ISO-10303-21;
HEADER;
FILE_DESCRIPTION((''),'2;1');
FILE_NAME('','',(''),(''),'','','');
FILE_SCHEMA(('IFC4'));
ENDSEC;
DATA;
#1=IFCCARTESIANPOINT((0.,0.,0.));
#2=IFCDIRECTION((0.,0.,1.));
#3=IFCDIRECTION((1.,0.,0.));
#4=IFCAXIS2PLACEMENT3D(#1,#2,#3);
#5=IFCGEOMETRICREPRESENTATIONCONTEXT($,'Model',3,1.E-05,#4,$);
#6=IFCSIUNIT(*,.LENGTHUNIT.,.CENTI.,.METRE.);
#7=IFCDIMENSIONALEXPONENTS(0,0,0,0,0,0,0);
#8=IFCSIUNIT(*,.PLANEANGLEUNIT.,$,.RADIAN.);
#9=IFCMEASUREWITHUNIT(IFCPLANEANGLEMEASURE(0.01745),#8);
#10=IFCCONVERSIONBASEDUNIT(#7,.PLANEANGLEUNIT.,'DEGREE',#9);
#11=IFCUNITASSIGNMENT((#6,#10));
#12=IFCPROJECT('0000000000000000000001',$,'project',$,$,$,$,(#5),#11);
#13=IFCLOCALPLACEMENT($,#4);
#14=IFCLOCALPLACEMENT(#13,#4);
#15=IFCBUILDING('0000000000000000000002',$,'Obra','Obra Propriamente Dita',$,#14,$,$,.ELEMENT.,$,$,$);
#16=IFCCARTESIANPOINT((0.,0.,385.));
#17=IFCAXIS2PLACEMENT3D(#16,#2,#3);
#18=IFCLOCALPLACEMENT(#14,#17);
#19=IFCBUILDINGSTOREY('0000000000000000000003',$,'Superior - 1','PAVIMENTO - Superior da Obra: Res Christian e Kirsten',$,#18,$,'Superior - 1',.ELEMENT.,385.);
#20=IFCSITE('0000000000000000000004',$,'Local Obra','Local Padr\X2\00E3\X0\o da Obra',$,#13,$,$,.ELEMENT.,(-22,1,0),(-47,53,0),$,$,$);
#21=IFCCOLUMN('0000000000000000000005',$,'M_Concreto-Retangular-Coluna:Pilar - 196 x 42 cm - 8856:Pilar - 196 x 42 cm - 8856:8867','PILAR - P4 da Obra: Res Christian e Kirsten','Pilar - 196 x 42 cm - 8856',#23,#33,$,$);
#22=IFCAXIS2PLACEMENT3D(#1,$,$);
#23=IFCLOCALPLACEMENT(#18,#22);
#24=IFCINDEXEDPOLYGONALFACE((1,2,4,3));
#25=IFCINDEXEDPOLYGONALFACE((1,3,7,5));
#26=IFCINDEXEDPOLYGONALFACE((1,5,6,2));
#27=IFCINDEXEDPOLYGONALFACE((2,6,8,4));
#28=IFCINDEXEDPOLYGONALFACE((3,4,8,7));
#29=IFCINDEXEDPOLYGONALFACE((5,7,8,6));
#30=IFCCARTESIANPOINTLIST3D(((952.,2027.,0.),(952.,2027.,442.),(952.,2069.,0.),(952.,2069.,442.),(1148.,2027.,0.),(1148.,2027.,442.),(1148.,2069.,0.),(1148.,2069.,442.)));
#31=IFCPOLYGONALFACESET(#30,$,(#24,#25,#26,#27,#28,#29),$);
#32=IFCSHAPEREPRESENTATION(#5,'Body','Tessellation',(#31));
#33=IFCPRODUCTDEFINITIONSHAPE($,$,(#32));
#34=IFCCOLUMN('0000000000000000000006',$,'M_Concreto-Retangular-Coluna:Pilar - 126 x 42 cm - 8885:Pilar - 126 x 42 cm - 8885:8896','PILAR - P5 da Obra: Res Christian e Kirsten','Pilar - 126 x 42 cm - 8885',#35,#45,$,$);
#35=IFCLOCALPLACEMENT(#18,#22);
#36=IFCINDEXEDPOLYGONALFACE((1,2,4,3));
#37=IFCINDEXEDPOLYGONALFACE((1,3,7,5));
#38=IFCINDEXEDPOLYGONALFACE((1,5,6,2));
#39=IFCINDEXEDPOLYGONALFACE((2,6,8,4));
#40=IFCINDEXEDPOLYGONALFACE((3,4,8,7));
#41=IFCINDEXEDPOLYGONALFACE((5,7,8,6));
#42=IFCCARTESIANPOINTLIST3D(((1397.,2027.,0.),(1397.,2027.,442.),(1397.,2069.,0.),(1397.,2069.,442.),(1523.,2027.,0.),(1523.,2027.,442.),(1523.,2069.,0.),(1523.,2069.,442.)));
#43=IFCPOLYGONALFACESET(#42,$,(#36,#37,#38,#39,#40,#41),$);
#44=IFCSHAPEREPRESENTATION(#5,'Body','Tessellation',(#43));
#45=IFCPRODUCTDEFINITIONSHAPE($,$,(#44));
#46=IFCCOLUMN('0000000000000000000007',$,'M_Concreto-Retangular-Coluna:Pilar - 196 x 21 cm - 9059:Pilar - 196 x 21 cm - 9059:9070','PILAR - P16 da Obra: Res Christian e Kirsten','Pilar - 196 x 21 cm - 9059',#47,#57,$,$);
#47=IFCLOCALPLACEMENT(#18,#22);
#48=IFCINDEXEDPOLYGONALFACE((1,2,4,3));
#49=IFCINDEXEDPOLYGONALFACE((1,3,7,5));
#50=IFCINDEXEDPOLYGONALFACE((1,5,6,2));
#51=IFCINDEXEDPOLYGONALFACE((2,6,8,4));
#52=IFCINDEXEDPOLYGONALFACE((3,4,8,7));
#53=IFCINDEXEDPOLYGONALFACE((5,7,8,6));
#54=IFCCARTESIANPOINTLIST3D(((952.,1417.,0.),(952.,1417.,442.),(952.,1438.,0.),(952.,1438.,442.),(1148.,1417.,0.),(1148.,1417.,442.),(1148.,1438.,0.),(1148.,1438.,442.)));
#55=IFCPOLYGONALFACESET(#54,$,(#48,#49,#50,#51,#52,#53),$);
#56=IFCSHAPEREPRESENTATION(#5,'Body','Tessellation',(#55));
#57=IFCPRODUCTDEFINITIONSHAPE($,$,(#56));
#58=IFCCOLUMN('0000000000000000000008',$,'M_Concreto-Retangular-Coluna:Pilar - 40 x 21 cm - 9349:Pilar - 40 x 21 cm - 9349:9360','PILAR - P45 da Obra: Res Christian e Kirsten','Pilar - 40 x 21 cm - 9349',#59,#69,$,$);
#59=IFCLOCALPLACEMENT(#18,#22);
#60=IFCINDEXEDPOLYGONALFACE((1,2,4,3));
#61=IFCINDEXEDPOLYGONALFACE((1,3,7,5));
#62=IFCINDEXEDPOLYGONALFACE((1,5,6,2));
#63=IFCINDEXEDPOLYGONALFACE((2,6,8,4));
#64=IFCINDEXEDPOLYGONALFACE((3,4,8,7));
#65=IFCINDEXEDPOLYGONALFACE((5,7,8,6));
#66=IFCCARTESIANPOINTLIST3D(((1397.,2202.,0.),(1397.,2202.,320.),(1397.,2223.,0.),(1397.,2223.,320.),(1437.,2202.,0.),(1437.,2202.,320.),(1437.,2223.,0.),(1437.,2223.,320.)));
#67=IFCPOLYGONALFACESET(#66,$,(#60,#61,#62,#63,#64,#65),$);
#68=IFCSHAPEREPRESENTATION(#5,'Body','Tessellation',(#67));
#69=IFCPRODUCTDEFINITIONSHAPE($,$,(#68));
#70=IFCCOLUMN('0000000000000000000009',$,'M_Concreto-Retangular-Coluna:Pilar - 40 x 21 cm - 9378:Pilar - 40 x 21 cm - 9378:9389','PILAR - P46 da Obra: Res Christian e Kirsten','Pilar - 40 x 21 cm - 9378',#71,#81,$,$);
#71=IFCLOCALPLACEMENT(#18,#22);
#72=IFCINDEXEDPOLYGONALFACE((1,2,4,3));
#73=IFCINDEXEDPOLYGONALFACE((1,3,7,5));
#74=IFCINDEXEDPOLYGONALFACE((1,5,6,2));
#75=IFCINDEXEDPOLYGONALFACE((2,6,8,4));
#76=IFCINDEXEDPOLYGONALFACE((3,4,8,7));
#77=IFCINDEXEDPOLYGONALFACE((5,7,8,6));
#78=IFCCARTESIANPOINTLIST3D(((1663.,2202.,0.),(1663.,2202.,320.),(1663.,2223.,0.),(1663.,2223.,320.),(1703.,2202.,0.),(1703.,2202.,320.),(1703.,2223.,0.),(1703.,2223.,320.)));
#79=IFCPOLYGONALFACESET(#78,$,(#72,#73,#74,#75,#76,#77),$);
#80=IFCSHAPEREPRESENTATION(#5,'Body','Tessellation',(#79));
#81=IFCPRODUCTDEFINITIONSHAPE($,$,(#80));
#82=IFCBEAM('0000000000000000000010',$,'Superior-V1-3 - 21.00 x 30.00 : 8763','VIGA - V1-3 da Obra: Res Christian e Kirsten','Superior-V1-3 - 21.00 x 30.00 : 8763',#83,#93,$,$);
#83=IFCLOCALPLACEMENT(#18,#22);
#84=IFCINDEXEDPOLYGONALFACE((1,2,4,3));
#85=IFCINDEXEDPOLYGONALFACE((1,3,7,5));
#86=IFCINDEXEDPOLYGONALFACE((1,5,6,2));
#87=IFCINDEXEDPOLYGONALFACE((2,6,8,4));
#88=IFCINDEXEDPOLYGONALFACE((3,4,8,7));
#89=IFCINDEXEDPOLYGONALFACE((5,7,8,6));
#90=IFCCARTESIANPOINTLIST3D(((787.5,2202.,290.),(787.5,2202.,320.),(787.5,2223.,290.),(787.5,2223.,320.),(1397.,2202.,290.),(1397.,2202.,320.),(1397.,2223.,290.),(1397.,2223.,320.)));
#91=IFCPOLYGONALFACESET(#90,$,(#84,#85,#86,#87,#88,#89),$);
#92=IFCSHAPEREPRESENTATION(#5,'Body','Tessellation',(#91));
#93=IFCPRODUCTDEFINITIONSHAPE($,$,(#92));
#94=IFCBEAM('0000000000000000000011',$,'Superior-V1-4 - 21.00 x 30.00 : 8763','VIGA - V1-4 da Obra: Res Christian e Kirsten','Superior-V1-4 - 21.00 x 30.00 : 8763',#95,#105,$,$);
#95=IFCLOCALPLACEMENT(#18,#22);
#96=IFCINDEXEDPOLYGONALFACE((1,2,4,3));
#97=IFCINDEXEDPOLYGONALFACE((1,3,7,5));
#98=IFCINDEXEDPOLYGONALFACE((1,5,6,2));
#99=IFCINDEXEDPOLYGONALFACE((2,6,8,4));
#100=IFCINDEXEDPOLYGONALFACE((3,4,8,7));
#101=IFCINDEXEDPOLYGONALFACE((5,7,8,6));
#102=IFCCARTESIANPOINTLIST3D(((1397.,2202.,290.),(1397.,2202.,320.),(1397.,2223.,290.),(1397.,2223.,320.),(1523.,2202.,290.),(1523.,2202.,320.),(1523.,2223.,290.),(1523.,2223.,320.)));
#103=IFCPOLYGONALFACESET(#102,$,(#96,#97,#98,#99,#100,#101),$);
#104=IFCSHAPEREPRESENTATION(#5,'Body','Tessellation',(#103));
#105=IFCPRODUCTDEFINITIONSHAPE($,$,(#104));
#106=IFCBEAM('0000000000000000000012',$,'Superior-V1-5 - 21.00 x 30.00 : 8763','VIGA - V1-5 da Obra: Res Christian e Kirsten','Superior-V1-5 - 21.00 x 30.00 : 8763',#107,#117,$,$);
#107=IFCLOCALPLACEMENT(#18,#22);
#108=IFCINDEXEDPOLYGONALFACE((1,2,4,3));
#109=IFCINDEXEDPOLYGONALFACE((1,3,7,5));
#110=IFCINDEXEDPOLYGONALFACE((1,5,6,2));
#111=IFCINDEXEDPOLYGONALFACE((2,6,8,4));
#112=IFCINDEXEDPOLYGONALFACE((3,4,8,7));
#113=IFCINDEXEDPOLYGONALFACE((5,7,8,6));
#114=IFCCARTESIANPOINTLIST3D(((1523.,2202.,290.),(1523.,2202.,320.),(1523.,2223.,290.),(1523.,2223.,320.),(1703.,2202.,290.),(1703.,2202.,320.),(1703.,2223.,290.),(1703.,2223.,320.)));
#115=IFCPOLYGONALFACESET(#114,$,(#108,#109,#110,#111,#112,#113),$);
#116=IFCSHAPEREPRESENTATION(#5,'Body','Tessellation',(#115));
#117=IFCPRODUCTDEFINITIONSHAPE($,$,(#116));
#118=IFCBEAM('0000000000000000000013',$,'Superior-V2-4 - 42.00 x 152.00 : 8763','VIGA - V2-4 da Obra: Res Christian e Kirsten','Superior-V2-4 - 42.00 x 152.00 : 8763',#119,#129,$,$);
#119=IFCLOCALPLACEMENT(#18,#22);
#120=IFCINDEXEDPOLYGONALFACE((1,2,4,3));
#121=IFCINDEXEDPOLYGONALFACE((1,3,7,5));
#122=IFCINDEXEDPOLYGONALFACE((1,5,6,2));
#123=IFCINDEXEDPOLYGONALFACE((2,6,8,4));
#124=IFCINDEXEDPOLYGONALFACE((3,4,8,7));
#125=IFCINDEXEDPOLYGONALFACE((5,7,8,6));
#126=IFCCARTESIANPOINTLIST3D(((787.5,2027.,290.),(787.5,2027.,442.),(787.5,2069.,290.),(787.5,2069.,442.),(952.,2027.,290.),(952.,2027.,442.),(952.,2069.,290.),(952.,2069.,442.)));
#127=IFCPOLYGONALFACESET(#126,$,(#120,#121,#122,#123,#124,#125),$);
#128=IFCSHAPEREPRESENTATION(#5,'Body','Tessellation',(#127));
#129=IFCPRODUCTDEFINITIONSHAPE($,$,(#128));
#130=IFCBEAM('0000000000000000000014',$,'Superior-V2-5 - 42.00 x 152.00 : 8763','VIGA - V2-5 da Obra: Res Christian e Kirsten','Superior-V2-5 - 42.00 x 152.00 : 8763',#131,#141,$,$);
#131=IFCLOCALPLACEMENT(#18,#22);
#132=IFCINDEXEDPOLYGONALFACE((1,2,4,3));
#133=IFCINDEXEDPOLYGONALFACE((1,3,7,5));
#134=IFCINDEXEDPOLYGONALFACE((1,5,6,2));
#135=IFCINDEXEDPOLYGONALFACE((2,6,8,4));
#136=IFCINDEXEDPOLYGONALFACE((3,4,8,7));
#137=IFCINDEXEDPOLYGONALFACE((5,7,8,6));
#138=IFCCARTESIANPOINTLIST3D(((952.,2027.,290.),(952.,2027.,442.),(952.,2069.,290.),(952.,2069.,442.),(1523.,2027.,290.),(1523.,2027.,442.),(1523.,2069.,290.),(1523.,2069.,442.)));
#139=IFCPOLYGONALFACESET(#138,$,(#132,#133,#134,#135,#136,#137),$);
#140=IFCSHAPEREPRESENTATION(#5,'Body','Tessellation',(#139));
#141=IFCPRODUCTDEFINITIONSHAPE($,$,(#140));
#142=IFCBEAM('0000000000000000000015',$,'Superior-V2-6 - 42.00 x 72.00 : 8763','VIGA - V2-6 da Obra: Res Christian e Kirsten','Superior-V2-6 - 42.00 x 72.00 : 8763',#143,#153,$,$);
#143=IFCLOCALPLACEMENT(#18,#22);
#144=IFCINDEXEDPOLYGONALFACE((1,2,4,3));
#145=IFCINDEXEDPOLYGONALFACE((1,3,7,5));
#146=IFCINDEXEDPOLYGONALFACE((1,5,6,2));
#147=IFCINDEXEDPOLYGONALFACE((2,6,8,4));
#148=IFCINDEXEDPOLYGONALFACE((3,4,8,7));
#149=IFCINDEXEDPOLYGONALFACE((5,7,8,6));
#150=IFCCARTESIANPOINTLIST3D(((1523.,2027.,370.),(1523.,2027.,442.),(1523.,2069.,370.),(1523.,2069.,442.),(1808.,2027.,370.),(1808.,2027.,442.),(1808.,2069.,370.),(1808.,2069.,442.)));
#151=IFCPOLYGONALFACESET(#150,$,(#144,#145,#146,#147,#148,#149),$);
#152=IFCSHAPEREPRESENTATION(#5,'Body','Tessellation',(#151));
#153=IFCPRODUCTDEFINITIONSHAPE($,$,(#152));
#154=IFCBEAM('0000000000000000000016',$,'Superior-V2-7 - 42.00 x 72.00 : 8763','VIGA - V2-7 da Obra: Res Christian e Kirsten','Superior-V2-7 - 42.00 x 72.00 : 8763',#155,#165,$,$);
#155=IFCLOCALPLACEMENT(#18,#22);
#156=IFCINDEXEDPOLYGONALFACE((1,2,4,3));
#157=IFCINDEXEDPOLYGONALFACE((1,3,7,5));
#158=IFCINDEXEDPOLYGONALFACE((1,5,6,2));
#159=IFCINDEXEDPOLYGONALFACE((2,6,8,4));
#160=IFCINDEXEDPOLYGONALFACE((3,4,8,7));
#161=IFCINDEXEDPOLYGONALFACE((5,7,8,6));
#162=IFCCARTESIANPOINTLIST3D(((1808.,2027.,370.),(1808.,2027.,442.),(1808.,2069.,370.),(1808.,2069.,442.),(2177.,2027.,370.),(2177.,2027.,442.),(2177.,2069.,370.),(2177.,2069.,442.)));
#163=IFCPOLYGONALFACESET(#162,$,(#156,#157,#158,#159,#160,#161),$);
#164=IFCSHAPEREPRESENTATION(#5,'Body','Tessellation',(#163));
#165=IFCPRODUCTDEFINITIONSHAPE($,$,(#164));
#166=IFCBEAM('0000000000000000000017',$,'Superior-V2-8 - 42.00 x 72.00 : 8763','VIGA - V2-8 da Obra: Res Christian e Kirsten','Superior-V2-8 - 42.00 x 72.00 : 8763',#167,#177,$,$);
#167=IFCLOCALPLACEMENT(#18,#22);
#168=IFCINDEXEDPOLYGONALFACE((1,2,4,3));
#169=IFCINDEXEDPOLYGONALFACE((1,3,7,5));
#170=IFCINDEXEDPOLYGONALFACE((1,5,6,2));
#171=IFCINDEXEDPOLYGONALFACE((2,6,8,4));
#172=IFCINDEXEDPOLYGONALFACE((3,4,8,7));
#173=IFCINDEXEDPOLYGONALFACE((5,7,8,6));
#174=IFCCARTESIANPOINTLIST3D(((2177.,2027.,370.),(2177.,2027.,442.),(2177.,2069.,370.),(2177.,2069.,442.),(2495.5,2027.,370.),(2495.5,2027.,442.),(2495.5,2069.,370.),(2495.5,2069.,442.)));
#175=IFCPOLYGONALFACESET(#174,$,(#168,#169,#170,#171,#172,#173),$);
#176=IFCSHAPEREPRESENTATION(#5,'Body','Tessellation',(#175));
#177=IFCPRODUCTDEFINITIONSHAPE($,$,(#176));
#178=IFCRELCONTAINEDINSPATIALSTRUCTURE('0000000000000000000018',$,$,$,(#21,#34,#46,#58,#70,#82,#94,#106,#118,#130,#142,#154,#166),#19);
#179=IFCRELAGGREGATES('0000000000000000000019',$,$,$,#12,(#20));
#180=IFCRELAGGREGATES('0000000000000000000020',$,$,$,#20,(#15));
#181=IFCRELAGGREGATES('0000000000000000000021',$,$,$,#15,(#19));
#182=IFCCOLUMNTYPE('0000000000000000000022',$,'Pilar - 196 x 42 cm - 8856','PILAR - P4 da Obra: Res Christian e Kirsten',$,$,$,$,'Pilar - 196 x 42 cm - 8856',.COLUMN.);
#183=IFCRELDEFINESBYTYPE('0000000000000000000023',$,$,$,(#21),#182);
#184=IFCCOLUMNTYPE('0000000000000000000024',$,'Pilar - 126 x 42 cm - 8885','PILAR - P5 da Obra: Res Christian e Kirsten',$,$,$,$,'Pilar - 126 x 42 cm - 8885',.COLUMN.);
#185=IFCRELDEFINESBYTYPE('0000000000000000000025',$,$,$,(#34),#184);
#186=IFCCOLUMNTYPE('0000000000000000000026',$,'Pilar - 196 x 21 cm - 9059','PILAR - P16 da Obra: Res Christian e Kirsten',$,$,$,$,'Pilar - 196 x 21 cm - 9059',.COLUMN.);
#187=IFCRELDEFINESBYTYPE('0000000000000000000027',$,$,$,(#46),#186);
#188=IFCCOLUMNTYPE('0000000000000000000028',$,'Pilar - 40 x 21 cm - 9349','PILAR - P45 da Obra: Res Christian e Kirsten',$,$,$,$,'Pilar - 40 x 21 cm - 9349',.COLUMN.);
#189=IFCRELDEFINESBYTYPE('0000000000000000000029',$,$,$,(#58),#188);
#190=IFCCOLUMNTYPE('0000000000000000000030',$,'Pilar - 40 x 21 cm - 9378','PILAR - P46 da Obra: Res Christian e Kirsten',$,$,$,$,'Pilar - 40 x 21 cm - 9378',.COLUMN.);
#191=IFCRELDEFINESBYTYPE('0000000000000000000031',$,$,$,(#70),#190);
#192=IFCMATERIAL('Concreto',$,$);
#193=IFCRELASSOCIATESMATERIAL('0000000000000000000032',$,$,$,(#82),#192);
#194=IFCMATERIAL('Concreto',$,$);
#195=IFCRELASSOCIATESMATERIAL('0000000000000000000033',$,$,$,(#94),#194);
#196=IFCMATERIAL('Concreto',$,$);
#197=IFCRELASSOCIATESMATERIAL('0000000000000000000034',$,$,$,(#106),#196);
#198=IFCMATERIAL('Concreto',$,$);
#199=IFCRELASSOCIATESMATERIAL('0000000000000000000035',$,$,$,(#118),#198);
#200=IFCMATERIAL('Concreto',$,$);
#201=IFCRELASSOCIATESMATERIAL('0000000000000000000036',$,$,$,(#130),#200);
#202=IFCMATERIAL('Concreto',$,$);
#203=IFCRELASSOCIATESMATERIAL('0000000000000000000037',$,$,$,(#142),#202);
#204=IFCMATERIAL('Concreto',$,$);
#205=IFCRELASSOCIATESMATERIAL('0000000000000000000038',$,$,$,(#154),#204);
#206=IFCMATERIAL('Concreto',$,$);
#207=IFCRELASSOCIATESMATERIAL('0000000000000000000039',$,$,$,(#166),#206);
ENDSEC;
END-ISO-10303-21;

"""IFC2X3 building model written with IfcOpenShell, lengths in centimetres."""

from ifc_helpers import new_model, entity, si_unit, converted_unit, frame, origin, origin_with_axes, origin_2d_with_axis, place, context, project, spatial, polyline, rectangle, outline, extrude, source, transform, mapped, material, type_object, type_shapes, element, save


model = new_model("IFC2X3")

# Units and contexts
model_context = context("Model", 3, precision=1e-05, world=origin_with_axes())
ifc_project = project(units=[si_unit("LENGTHUNIT", "METRE", prefix="CENTI"), converted_unit("PLANEANGLEUNIT", "DEGREE", entity("IfcPlaneAngleMeasure", 0.01745), si_unit("PLANEANGLEUNIT", "RADIAN"), dimensions=[0, 0, 0, 0, 0, 0, 0])], contexts=[model_context])

# Site, building, storey
site_placement = place(None, origin_with_axes())
site = spatial("IfcSite", under=ifc_project, at=site_placement, Name="Local Obra", Description="Local Padrão da Obra", CompositionType="ELEMENT", RefLatitude=(-22, 1, 0), RefLongitude=(-47, 53, 0))
building_placement = place(site_placement, origin_with_axes())
building = spatial("IfcBuilding", under=site, at=building_placement, Name="Obra", Description="Obra Propriamente Dita", CompositionType="ELEMENT")
storey_placement = place(building_placement, frame((0.0, 0.0, 385.0), z_axis=(0.0, 0.0, 1.0), x_axis=(1.0, 0.0, 0.0)))
storey = spatial("IfcBuildingStorey", under=building, at=storey_placement, Name="Superior - 1", Description="PAVIMENTO - Superior da Obra: Res Christian e Kirsten", LongName="Superior - 1", CompositionType="ELEMENT", Elevation=385.0)

# Columns
column_type_1 = type_object("IfcColumnType", Name="Pilar - 196 x 42 cm - 8856", Description="PILAR - P4 da Obra: Res Christian e Kirsten", ElementType="Pilar - 196 x 42 cm - 8856", PredefinedType="COLUMN")
shared_shape_1 = source(origin(), model_context, "Body", "SweptSolid", [
    extrude(rectangle(XDim=196.0, YDim=42.0, at=origin_2d_with_axis()), origin(), (0.0, 0.0, 1.0), 442.0),
])
type_shapes(column_type_1, [shared_shape_1])
column_1_placement = place(storey_placement, frame((1050.0, 2048.0, 0.0), z_axis=(0.0, 0.0, 1.0), x_axis=(1.0, 0.0, 0.0)))
element("IfcColumn", 1, at=column_1_placement, inside=storey, type_object=column_type_1, Name="M_Concreto-Retangular-Coluna:Pilar - 196 x 42 cm - 8856:Pilar - 196 x 42 cm - 8856:8867", Description="PILAR - P4 da Obra: Res Christian e Kirsten", ObjectType="Pilar - 196 x 42 cm - 8856", context=model_context, shape_type="MappedRepresentation", body=[
    mapped(shared_shape_1, transform((0.0, 0.0, 0.0), scale=1.0)),
])
column_type_2 = type_object("IfcColumnType", Name="Pilar - 126 x 42 cm - 8885", Description="PILAR - P5 da Obra: Res Christian e Kirsten", ElementType="Pilar - 126 x 42 cm - 8885", PredefinedType="COLUMN")
shared_shape_2 = source(origin(), model_context, "Body", "SweptSolid", [
    extrude(rectangle(XDim=126.0, YDim=42.0, at=origin_2d_with_axis()), origin(), (0.0, 0.0, 1.0), 442.0),
])
type_shapes(column_type_2, [shared_shape_2])
column_2_placement = place(storey_placement, frame((1460.0, 2048.0, 0.0), z_axis=(0.0, 0.0, 1.0), x_axis=(1.0, 0.0, 0.0)))
element("IfcColumn", 2, at=column_2_placement, inside=storey, type_object=column_type_2, Name="M_Concreto-Retangular-Coluna:Pilar - 126 x 42 cm - 8885:Pilar - 126 x 42 cm - 8885:8896", Description="PILAR - P5 da Obra: Res Christian e Kirsten", ObjectType="Pilar - 126 x 42 cm - 8885", context=model_context, shape_type="MappedRepresentation", body=[
    mapped(shared_shape_2, transform((0.0, 0.0, 0.0), scale=1.0)),
])
column_type_3 = type_object("IfcColumnType", Name="Pilar - 196 x 21 cm - 9059", Description="PILAR - P16 da Obra: Res Christian e Kirsten", ElementType="Pilar - 196 x 21 cm - 9059", PredefinedType="COLUMN")
shared_shape_3 = source(origin(), model_context, "Body", "SweptSolid", [
    extrude(rectangle(XDim=196.0, YDim=21.0, at=origin_2d_with_axis()), origin(), (0.0, 0.0, 1.0), 442.0),
])
type_shapes(column_type_3, [shared_shape_3])
column_3_placement = place(storey_placement, frame((1050.0, 1427.5, 0.0), z_axis=(0.0, 0.0, 1.0), x_axis=(1.0, 0.0, 0.0)))
element("IfcColumn", 3, at=column_3_placement, inside=storey, type_object=column_type_3, Name="M_Concreto-Retangular-Coluna:Pilar - 196 x 21 cm - 9059:Pilar - 196 x 21 cm - 9059:9070", Description="PILAR - P16 da Obra: Res Christian e Kirsten", ObjectType="Pilar - 196 x 21 cm - 9059", context=model_context, shape_type="MappedRepresentation", body=[
    mapped(shared_shape_3, transform((0.0, 0.0, 0.0), scale=1.0)),
])
column_type_4 = type_object("IfcColumnType", Name="Pilar - 40 x 21 cm - 9349", Description="PILAR - P45 da Obra: Res Christian e Kirsten", ElementType="Pilar - 40 x 21 cm - 9349", PredefinedType="COLUMN")
shared_shape_4 = source(origin(), model_context, "Body", "SweptSolid", [
    extrude(rectangle(XDim=40.0, YDim=21.0, at=origin_2d_with_axis()), origin(), (0.0, 0.0, 1.0), 320.0),
])
type_shapes(column_type_4, [shared_shape_4])
column_4_placement = place(storey_placement, frame((1417.0, 2212.5, 0.0), z_axis=(0.0, 0.0, 1.0), x_axis=(1.0, 0.0, 0.0)))
element("IfcColumn", 4, at=column_4_placement, inside=storey, type_object=column_type_4, Name="M_Concreto-Retangular-Coluna:Pilar - 40 x 21 cm - 9349:Pilar - 40 x 21 cm - 9349:9360", Description="PILAR - P45 da Obra: Res Christian e Kirsten", ObjectType="Pilar - 40 x 21 cm - 9349", context=model_context, shape_type="MappedRepresentation", body=[
    mapped(shared_shape_4, transform((0.0, 0.0, 0.0), scale=1.0)),
])
column_type_5 = type_object("IfcColumnType", Name="Pilar - 40 x 21 cm - 9378", Description="PILAR - P46 da Obra: Res Christian e Kirsten", ElementType="Pilar - 40 x 21 cm - 9378", PredefinedType="COLUMN")
shared_shape_5 = source(origin(), model_context, "Body", "SweptSolid", [
    extrude(rectangle(XDim=40.0, YDim=21.0, at=origin_2d_with_axis()), origin(), (0.0, 0.0, 1.0), 320.0),
])
type_shapes(column_type_5, [shared_shape_5])
column_5_placement = place(storey_placement, frame((1683.0, 2212.5, 0.0), z_axis=(0.0, 0.0, 1.0), x_axis=(1.0, 0.0, 0.0)))
element("IfcColumn", 5, at=column_5_placement, inside=storey, type_object=column_type_5, Name="M_Concreto-Retangular-Coluna:Pilar - 40 x 21 cm - 9378:Pilar - 40 x 21 cm - 9378:9389", Description="PILAR - P46 da Obra: Res Christian e Kirsten", ObjectType="Pilar - 40 x 21 cm - 9378", context=model_context, shape_type="MappedRepresentation", body=[
    mapped(shared_shape_5, transform((0.0, 0.0, 0.0), scale=1.0)),
])

# Beams
ifc_material_1 = material(Name="Concreto")
beam_1_placement = place(storey_placement, frame((787.5, 2223.0, 320.0), z_axis=(1.0, 0.0, 0.0), x_axis=(0.0, -1.0, 0.0)))
element("IfcBeam", 6, at=beam_1_placement, inside=storey, material=ifc_material_1, Name="Superior-V1-3 - 21.00 x 30.00 : 8763", Description="VIGA - V1-3 da Obra: Res Christian e Kirsten", ObjectType="Superior-V1-3 - 21.00 x 30.00 : 8763", context=model_context, shape_type="SweptSolid", body=[
    extrude(outline(polyline([(0.0, 0.0), (21.0, 0.0), (21.0, 30.0), (0.0, 30.0), (0.0, 0.0)])), origin_with_axes(), (0.0, 0.0, 1.0), 609.5),
])
ifc_material_2 = material(Name="Concreto")
beam_2_placement = place(storey_placement, frame((1397.0, 2223.0, 320.0), z_axis=(1.0, 0.0, 0.0), x_axis=(0.0, -1.0, 0.0)))
element("IfcBeam", 7, at=beam_2_placement, inside=storey, material=ifc_material_2, Name="Superior-V1-4 - 21.00 x 30.00 : 8763", Description="VIGA - V1-4 da Obra: Res Christian e Kirsten", ObjectType="Superior-V1-4 - 21.00 x 30.00 : 8763", context=model_context, shape_type="SweptSolid", body=[
    extrude(outline(polyline([(0.0, 0.0), (21.0, 0.0), (21.0, 30.0), (0.0, 30.0), (0.0, 0.0)])), origin_with_axes(), (0.0, 0.0, 1.0), 126.0),
])
ifc_material_3 = material(Name="Concreto")
beam_3_placement = place(storey_placement, frame((1523.0, 2223.0, 320.0), z_axis=(1.0, 0.0, 0.0), x_axis=(0.0, -1.0, 0.0)))
element("IfcBeam", 8, at=beam_3_placement, inside=storey, material=ifc_material_3, Name="Superior-V1-5 - 21.00 x 30.00 : 8763", Description="VIGA - V1-5 da Obra: Res Christian e Kirsten", ObjectType="Superior-V1-5 - 21.00 x 30.00 : 8763", context=model_context, shape_type="SweptSolid", body=[
    extrude(outline(polyline([(0.0, 0.0), (21.0, 0.0), (21.0, 30.0), (0.0, 30.0), (0.0, 0.0)])), origin_with_axes(), (0.0, 0.0, 1.0), 180.0),
])
ifc_material_4 = material(Name="Concreto")
beam_4_placement = place(storey_placement, frame((787.5, 2048.0, 442.0), z_axis=(1.0, 0.0, 0.0), x_axis=(0.0, -1.0, 0.0)))
element("IfcBeam", 9, at=beam_4_placement, inside=storey, material=ifc_material_4, Name="Superior-V2-4 - 42.00 x 152.00 : 8763", Description="VIGA - V2-4 da Obra: Res Christian e Kirsten", ObjectType="Superior-V2-4 - 42.00 x 152.00 : 8763", context=model_context, shape_type="SweptSolid", body=[
    extrude(outline(polyline([(-21.0, 0.0), (21.0, 0.0), (21.0, 152.0), (-21.0, 152.0), (-21.0, 0.0)])), origin_with_axes(), (0.0, 0.0, 1.0), 164.5),
])
ifc_material_5 = material(Name="Concreto")
beam_5_placement = place(storey_placement, frame((952.0, 2048.0, 442.0), z_axis=(1.0, 0.0, 0.0), x_axis=(0.0, -1.0, 0.0)))
element("IfcBeam", 10, at=beam_5_placement, inside=storey, material=ifc_material_5, Name="Superior-V2-5 - 42.00 x 152.00 : 8763", Description="VIGA - V2-5 da Obra: Res Christian e Kirsten", ObjectType="Superior-V2-5 - 42.00 x 152.00 : 8763", context=model_context, shape_type="SweptSolid", body=[
    extrude(outline(polyline([(-21.0, 0.0), (21.0, 0.0), (21.0, 152.0), (-21.0, 152.0), (-21.0, 0.0)])), origin_with_axes(), (0.0, 0.0, 1.0), 571.0),
])
ifc_material_6 = material(Name="Concreto")
beam_6_placement = place(storey_placement, frame((1523.0, 2048.0, 442.0), z_axis=(1.0, 0.0, 0.0), x_axis=(0.0, -1.0, 0.0)))
element("IfcBeam", 11, at=beam_6_placement, inside=storey, material=ifc_material_6, Name="Superior-V2-6 - 42.00 x 72.00 : 8763", Description="VIGA - V2-6 da Obra: Res Christian e Kirsten", ObjectType="Superior-V2-6 - 42.00 x 72.00 : 8763", context=model_context, shape_type="SweptSolid", body=[
    extrude(outline(polyline([(-21.0, 0.0), (21.0, 0.0), (21.0, 72.0), (-21.0, 72.0), (-21.0, 0.0)])), origin_with_axes(), (0.0, 0.0, 1.0), 285.0),
])
ifc_material_7 = material(Name="Concreto")
beam_7_placement = place(storey_placement, frame((1808.0, 2048.0, 442.0), z_axis=(1.0, 0.0, 0.0), x_axis=(0.0, -1.0, 0.0)))
element("IfcBeam", 12, at=beam_7_placement, inside=storey, material=ifc_material_7, Name="Superior-V2-7 - 42.00 x 72.00 : 8763", Description="VIGA - V2-7 da Obra: Res Christian e Kirsten", ObjectType="Superior-V2-7 - 42.00 x 72.00 : 8763", context=model_context, shape_type="SweptSolid", body=[
    extrude(outline(polyline([(-21.0, 0.0), (21.0, 0.0), (21.0, 72.0), (-21.0, 72.0), (-21.0, 0.0)])), origin_with_axes(), (0.0, 0.0, 1.0), 369.0),
])
ifc_material_8 = material(Name="Concreto")
beam_8_placement = place(storey_placement, frame((2177.0, 2048.0, 442.0), z_axis=(1.0, 0.0, 0.0), x_axis=(0.0, -1.0, 0.0)))
element("IfcBeam", 13, at=beam_8_placement, inside=storey, material=ifc_material_8, Name="Superior-V2-8 - 42.00 x 72.00 : 8763", Description="VIGA - V2-8 da Obra: Res Christian e Kirsten", ObjectType="Superior-V2-8 - 42.00 x 72.00 : 8763", context=model_context, shape_type="SweptSolid", body=[
    extrude(outline(polyline([(-21.0, 0.0), (21.0, 0.0), (21.0, 72.0), (-21.0, 72.0), (-21.0, 0.0)])), origin_with_axes(), (0.0, 0.0, 1.0), 318.5),
])

save(model, "model.ifc")
